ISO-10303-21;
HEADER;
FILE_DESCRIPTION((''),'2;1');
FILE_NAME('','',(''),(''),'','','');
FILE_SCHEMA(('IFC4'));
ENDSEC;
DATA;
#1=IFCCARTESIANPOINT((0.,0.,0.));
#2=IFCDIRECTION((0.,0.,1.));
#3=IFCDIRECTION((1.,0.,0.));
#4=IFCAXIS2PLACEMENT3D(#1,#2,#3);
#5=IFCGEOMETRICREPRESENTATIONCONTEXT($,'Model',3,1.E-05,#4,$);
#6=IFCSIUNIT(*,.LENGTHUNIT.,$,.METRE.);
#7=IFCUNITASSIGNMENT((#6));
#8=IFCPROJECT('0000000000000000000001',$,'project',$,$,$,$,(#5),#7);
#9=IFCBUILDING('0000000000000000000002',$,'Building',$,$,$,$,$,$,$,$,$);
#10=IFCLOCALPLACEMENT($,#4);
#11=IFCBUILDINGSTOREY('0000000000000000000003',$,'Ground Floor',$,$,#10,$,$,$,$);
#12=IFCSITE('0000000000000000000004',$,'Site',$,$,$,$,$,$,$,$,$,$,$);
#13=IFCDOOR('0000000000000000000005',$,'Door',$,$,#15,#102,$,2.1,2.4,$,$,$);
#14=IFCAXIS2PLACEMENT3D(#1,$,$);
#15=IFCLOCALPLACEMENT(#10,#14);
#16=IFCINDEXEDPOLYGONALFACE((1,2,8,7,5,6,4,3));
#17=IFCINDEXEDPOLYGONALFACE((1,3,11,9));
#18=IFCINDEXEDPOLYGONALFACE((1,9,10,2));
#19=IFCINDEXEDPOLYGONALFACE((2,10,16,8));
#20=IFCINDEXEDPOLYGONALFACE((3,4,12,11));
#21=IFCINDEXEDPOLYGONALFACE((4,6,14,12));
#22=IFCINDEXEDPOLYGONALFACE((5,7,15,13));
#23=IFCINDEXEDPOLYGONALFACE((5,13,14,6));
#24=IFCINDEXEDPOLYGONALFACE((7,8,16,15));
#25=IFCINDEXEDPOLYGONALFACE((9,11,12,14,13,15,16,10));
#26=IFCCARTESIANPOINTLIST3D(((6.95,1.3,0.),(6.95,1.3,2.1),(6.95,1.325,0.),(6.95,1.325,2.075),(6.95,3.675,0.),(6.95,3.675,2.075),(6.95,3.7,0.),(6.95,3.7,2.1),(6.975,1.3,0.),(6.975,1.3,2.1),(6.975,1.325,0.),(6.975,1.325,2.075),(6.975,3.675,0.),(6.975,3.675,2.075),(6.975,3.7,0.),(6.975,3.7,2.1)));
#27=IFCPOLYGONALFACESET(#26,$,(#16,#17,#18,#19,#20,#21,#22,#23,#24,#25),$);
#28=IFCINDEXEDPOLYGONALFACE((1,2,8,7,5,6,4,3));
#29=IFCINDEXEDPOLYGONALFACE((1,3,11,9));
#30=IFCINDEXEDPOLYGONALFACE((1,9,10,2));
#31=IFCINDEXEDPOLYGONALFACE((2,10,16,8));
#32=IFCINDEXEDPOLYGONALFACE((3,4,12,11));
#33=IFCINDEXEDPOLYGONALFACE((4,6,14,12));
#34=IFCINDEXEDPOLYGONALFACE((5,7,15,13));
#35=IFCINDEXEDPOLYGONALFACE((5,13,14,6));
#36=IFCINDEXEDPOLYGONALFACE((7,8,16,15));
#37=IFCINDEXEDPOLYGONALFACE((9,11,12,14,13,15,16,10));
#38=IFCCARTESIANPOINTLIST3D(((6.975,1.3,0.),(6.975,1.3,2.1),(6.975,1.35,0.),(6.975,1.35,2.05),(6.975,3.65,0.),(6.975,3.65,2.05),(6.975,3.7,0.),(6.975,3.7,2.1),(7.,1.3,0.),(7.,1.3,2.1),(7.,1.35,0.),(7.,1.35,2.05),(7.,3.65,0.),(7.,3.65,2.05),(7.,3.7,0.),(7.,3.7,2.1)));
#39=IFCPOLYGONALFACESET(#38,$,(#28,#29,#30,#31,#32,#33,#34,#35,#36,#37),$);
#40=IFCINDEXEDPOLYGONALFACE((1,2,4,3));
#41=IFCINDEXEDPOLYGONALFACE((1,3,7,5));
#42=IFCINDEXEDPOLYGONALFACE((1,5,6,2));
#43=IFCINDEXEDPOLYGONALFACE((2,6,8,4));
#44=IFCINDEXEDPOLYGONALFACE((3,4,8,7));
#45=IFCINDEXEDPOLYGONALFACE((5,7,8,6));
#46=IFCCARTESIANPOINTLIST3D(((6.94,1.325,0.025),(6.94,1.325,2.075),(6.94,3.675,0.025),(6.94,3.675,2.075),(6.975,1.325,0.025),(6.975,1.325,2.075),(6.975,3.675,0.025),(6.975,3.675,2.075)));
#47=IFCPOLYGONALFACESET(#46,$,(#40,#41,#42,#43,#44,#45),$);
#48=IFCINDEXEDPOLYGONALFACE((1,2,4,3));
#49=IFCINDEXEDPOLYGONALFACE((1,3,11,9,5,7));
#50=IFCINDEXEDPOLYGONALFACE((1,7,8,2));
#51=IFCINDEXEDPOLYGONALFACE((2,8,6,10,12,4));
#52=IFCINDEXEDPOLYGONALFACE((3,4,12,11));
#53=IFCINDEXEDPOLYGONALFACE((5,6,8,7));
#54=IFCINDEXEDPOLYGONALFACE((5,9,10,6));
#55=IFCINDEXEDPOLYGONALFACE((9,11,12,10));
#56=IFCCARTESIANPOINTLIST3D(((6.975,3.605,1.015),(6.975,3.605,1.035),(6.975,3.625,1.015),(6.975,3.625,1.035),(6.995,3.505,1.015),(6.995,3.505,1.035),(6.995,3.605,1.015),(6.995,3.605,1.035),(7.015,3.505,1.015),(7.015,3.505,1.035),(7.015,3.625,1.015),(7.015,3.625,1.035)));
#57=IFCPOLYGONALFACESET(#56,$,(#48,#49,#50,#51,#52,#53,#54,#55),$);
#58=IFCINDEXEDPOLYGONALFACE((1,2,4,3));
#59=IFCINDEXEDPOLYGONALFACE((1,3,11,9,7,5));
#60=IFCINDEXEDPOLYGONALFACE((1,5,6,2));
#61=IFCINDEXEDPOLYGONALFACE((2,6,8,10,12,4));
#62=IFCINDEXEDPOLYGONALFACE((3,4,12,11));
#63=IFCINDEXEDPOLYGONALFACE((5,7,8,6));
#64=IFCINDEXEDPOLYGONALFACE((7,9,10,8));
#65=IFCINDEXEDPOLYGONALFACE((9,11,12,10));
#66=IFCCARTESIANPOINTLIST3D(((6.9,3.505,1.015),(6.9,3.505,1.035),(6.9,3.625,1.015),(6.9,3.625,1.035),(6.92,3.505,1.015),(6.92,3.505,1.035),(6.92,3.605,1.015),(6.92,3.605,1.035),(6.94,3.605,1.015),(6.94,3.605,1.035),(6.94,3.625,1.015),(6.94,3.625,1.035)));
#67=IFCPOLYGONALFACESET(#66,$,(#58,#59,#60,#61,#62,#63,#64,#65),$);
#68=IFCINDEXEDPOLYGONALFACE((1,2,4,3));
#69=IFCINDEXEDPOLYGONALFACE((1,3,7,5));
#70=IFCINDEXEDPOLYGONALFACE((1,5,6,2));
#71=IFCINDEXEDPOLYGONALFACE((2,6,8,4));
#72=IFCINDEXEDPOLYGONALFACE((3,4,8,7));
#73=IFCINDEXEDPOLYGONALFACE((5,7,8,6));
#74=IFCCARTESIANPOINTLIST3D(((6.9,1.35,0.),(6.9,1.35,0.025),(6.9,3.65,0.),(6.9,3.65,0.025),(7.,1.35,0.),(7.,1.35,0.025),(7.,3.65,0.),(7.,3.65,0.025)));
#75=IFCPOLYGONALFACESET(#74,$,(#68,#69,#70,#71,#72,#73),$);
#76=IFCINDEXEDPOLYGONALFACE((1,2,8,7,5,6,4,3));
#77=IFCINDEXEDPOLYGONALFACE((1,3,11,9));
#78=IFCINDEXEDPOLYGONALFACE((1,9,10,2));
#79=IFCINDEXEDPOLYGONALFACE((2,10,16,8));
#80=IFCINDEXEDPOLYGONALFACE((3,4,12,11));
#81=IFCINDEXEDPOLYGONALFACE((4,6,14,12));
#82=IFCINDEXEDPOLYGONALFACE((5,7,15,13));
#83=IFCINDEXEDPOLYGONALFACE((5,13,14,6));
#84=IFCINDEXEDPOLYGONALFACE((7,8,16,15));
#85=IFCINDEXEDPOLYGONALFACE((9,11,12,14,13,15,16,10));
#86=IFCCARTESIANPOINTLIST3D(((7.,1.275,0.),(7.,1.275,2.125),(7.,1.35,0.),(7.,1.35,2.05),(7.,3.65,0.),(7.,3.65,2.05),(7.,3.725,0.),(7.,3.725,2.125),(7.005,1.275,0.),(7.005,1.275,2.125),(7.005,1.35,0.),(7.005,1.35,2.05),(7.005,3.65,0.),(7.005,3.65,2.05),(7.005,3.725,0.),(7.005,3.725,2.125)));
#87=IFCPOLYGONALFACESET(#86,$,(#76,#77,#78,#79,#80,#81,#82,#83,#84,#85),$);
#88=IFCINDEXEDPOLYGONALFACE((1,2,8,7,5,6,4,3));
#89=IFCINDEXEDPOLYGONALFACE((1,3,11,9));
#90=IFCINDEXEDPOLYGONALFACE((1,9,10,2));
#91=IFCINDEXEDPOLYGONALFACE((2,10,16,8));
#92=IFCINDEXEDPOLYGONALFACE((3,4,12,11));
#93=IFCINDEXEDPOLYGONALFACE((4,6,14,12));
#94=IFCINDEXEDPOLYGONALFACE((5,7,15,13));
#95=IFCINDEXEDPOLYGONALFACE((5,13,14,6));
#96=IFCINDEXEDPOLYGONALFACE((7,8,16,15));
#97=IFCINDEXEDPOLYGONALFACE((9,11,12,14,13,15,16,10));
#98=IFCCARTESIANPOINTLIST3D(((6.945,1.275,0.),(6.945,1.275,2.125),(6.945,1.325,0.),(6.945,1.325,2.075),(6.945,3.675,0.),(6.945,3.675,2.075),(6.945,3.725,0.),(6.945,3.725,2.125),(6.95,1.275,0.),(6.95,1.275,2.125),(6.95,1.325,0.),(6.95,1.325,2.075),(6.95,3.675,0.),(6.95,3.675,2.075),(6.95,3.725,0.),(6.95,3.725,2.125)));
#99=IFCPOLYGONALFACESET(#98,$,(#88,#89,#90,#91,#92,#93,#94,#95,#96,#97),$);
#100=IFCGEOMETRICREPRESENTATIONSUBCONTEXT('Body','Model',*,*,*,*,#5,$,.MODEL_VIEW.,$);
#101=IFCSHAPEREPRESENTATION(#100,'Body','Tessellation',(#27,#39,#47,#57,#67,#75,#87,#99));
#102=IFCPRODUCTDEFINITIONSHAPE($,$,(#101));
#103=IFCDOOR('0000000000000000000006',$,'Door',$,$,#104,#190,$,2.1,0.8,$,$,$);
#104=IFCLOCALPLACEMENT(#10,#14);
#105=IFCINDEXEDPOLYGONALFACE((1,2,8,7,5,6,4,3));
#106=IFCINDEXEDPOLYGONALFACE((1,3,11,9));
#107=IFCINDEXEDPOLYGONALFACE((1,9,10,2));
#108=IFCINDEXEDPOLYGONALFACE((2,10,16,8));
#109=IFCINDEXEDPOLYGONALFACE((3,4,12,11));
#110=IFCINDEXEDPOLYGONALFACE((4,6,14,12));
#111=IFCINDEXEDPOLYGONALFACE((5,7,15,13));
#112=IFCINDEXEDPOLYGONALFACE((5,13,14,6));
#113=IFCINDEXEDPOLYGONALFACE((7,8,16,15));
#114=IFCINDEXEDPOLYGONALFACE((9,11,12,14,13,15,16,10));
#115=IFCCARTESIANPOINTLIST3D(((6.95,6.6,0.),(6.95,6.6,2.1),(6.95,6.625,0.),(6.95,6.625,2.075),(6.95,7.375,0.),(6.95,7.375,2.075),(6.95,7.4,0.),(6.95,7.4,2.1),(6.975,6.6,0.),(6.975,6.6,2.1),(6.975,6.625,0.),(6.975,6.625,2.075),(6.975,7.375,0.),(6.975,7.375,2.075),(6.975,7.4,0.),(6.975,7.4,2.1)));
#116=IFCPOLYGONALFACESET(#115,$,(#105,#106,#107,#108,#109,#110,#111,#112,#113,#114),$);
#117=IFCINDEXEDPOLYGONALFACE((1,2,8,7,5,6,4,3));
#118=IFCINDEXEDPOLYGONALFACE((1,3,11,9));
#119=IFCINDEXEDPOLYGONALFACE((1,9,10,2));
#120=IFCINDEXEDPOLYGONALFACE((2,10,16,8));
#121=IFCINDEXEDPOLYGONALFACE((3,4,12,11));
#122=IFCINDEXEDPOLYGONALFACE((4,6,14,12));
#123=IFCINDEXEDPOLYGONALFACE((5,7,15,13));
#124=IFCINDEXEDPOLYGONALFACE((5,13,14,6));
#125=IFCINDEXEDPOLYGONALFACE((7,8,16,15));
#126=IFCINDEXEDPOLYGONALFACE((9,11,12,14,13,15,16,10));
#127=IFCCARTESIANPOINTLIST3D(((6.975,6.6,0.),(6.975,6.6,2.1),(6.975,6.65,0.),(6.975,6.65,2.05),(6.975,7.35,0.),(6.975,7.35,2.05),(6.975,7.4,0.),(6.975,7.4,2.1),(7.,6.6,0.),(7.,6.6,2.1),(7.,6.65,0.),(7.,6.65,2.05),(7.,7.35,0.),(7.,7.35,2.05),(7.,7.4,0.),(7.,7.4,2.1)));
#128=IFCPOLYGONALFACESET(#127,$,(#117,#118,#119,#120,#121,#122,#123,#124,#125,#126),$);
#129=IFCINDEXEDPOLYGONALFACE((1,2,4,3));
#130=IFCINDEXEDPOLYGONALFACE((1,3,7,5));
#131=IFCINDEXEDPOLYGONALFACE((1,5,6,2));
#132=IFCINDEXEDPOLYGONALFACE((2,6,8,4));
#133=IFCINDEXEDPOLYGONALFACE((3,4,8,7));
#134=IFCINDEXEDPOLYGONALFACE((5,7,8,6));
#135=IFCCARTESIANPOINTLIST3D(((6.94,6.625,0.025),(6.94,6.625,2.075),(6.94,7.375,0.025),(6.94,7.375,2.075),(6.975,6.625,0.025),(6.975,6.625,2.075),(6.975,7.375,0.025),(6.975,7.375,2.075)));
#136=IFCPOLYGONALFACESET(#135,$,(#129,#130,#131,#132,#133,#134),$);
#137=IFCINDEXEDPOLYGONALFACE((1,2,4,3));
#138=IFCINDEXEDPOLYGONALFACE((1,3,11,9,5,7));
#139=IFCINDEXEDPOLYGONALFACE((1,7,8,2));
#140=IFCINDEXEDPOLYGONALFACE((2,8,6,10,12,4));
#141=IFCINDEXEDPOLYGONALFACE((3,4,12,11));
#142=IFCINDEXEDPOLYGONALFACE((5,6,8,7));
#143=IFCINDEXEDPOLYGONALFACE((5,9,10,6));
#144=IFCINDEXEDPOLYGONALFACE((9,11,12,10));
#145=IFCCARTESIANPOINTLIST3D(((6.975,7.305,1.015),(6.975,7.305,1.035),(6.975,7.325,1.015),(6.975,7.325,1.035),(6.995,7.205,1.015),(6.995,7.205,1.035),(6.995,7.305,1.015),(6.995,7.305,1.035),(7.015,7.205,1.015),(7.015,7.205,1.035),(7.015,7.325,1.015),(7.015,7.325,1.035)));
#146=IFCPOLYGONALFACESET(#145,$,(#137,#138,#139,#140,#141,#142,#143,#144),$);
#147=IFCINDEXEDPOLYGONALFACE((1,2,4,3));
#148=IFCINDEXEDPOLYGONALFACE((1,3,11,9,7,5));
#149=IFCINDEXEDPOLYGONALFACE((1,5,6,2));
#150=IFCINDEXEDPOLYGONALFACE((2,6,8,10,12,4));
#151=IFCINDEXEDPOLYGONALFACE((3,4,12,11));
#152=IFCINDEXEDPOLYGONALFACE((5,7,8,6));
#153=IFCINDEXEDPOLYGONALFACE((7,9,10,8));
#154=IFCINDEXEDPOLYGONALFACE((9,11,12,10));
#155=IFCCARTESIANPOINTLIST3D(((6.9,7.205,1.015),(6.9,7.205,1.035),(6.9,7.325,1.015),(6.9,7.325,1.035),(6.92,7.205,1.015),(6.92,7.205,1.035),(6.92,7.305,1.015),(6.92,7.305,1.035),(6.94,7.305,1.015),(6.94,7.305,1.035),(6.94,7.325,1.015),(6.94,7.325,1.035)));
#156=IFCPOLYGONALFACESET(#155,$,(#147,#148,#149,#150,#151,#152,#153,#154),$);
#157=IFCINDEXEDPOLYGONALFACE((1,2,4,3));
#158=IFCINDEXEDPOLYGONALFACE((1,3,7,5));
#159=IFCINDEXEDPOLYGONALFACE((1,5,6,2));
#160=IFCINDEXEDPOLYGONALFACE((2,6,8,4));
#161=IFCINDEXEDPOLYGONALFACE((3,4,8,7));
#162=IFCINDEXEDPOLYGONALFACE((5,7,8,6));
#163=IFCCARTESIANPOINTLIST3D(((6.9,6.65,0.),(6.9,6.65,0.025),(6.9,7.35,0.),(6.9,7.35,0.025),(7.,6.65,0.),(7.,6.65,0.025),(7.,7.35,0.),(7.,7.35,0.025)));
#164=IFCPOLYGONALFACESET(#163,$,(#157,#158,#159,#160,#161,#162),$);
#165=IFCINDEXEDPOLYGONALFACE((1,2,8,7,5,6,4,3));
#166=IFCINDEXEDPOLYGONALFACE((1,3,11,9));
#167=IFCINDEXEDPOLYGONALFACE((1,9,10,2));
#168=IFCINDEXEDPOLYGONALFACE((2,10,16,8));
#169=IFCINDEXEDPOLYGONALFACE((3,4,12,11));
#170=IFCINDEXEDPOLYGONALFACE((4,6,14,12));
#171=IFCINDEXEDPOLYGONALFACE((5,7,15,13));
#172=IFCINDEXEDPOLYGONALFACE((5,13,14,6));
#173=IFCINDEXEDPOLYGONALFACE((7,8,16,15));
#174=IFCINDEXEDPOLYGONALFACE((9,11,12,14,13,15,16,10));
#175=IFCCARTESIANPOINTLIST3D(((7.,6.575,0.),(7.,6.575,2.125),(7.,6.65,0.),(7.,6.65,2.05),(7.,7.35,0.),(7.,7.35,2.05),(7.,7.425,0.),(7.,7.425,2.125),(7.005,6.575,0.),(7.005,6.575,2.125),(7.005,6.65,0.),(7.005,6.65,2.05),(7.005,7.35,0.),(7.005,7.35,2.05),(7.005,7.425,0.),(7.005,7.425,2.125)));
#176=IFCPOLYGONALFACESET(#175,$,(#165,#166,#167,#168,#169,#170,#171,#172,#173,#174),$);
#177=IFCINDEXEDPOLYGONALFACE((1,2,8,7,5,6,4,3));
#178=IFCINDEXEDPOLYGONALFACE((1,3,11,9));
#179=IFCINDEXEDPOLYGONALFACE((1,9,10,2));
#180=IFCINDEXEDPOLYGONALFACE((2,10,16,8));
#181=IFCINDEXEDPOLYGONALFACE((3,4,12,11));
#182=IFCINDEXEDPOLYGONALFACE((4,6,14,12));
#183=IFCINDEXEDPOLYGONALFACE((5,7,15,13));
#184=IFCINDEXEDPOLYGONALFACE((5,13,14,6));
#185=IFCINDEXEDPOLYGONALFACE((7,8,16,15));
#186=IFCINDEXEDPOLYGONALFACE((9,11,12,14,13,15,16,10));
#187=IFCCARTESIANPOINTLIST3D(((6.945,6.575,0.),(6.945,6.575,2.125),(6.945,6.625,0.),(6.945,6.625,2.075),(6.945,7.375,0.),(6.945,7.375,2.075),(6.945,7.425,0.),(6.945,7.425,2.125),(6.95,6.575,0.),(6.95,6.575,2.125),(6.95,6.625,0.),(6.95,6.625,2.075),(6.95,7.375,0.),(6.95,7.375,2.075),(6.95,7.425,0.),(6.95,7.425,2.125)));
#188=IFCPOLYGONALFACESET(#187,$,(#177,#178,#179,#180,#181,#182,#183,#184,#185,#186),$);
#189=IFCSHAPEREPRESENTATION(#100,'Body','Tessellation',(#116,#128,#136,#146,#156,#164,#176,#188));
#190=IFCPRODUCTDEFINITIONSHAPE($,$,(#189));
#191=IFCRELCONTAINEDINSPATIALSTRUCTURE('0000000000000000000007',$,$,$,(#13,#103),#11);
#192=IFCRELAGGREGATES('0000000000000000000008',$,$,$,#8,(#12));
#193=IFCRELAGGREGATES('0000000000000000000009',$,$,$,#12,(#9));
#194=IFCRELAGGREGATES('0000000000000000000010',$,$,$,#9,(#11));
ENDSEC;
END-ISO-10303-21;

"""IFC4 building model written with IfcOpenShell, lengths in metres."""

from ifc_helpers import new_model, si_unit, frame, origin_with_axes, place, context, subcontext, project, spatial, line, indexed_curve, outline, extrude, element, save


model = new_model("IFC4")

# Units and contexts
model_context = context("Model", 3, precision=1e-05, world=origin_with_axes())
body_context = subcontext(model_context, "Body", "Model", "MODEL_VIEW")
ifc_project = project(units=[si_unit("LENGTHUNIT", "METRE")], contexts=[model_context])

# Site, building, storey
site = spatial("IfcSite", under=ifc_project, Name="Site")
building = spatial("IfcBuilding", under=site, Name="Building")
storey_placement = place(None, origin_with_axes())
storey = spatial("IfcBuildingStorey", under=building, at=storey_placement, Name="Ground Floor")

# Doors
door_1_placement = place(storey_placement, frame((7.0, 1.3, 0.0), z_axis=(0.0, 0.0, 1.0), x_axis=(0.0, 1.0, 0.0)))
element("IfcDoor", 1, at=door_1_placement, inside=storey, Name="Door", OverallHeight=2.1, OverallWidth=2.4, context=body_context, shape_type="SweptSolid", body=[
    extrude(outline(indexed_curve([(0.0, 0.0), (0.0, 2.1), (2.4, 2.1), (2.4, 0.0), (2.375, 0.0), (2.375, 2.075), (0.025, 2.075), (0.025, 0.0)], segments=[line(1, 2, 3, 4, 5, 6, 7, 8, 1)])), frame((0.0, 0.025, 0.0), z_axis=(0.0, -1.0, 0.0), x_axis=(1.0, 0.0, 0.0)), (0.0, 0.0, -1.0), 0.025),
    extrude(outline(indexed_curve([(0.0, 0.0), (0.0, 2.1), (2.4, 2.1), (2.4, 0.0), (2.35, 0.0), (2.35, 2.05), (0.05, 2.05), (0.05, 0.0)], segments=[line(1, 2, 3, 4, 5, 6, 7, 8, 1)])), frame((0.0, 0.0, 0.0), z_axis=(0.0, -1.0, 0.0), x_axis=(1.0, 0.0, 0.0)), (0.0, 0.0, -1.0), 0.025),
    extrude(outline(indexed_curve([(0.0, 0.0), (2.35, 0.0), (2.35, 0.035), (0.0, 0.035)], segments=[line(1, 2, 3, 4, 1)])), frame((0.025, 0.025, 0.025), z_axis=(0.0, 0.0, 1.0), x_axis=(1.0, 0.0, 0.0)), (0.0, 0.0, 1.0), 2.05),
    extrude(outline(indexed_curve([(0.0, 0.0), (0.0, -0.04), (-0.12, -0.04), (-0.12, -0.02), (-0.02, -0.02), (-0.02, 0.0)], segments=[line(1, 2, 3, 4, 5, 6, 1)])), frame((2.325, 0.025, 1.015), z_axis=(0.0, 0.0, 1.0), x_axis=(1.0, 0.0, 0.0)), (0.0, 0.0, 1.0), 0.02),
    extrude(outline(indexed_curve([(0.0, 0.0), (0.0, 0.04), (-0.12, 0.04), (-0.12, 0.02), (-0.02, 0.02), (-0.02, 0.0)], segments=[line(1, 2, 3, 4, 5, 6, 1)])), frame((2.325, 0.06, 1.015), z_axis=(0.0, 0.0, 1.0), x_axis=(1.0, 0.0, 0.0)), (0.0, 0.0, 1.0), 0.02),
    extrude(outline(indexed_curve([(0.0, 0.0), (2.3, 0.0), (2.3, 0.1), (0.0, 0.1)], segments=[line(1, 2, 3, 4, 1)])), frame((0.05, 0.0, 0.0), z_axis=(0.0, 0.0, 1.0), x_axis=(1.0, 0.0, 0.0)), (0.0, 0.0, 1.0), 0.025),
    extrude(outline(indexed_curve([(0.0, 0.0), (0.0, 2.125), (2.45, 2.125), (2.45, 0.0), (2.375, 0.0), (2.375, 2.05), (0.075, 2.05), (0.075, 0.0)], segments=[line(1, 2, 3, 4, 5, 6, 7, 8, 1)])), frame((-0.025, -0.005, 0.0), z_axis=(0.0, -1.0, 0.0), x_axis=(1.0, 0.0, 0.0)), (0.0, 0.0, -1.0), 0.005),
    extrude(outline(indexed_curve([(0.0, 0.0), (0.0, 2.125), (2.45, 2.125), (2.45, 0.0), (2.4, 0.0), (2.4, 2.075), (0.05, 2.075), (0.05, 0.0)], segments=[line(1, 2, 3, 4, 5, 6, 7, 8, 1)])), frame((-0.025, 0.05, 0.0), z_axis=(0.0, -1.0, 0.0), x_axis=(1.0, 0.0, 0.0)), (0.0, 0.0, -1.0), 0.005),
])
door_2_placement = place(storey_placement, frame((7.0, 6.6, 0.0), z_axis=(0.0, 0.0, 1.0), x_axis=(0.0, 1.0, 0.0)))
element("IfcDoor", 2, at=door_2_placement, inside=storey, Name="Door", OverallHeight=2.1, OverallWidth=0.8, context=body_context, shape_type="SweptSolid", body=[
    extrude(outline(indexed_curve([(0.0, 0.0), (0.0, 2.1), (0.8, 2.1), (0.8, 0.0), (0.775, 0.0), (0.775, 2.075), (0.025, 2.075), (0.025, 0.0)], segments=[line(1, 2, 3, 4, 5, 6, 7, 8, 1)])), frame((0.0, 0.025, 0.0), z_axis=(0.0, -1.0, 0.0), x_axis=(1.0, 0.0, 0.0)), (0.0, 0.0, -1.0), 0.025),
    extrude(outline(indexed_curve([(0.0, 0.0), (0.0, 2.1), (0.8, 2.1), (0.8, 0.0), (0.75, 0.0), (0.75, 2.05), (0.05, 2.05), (0.05, 0.0)], segments=[line(1, 2, 3, 4, 5, 6, 7, 8, 1)])), frame((0.0, 0.0, 0.0), z_axis=(0.0, -1.0, 0.0), x_axis=(1.0, 0.0, 0.0)), (0.0, 0.0, -1.0), 0.025),
    extrude(outline(indexed_curve([(0.0, 0.0), (0.75, 0.0), (0.75, 0.035), (0.0, 0.035)], segments=[line(1, 2, 3, 4, 1)])), frame((0.025, 0.025, 0.025), z_axis=(0.0, 0.0, 1.0), x_axis=(1.0, 0.0, 0.0)), (0.0, 0.0, 1.0), 2.05),
    extrude(outline(indexed_curve([(0.0, 0.0), (0.0, -0.04), (-0.12, -0.04), (-0.12, -0.02), (-0.02, -0.02), (-0.02, 0.0)], segments=[line(1, 2, 3, 4, 5, 6, 1)])), frame((0.725, 0.025, 1.015), z_axis=(0.0, 0.0, 1.0), x_axis=(1.0, 0.0, 0.0)), (0.0, 0.0, 1.0), 0.02),
    extrude(outline(indexed_curve([(0.0, 0.0), (0.0, 0.04), (-0.12, 0.04), (-0.12, 0.02), (-0.02, 0.02), (-0.02, 0.0)], segments=[line(1, 2, 3, 4, 5, 6, 1)])), frame((0.725, 0.06, 1.015), z_axis=(0.0, 0.0, 1.0), x_axis=(1.0, 0.0, 0.0)), (0.0, 0.0, 1.0), 0.02),
    extrude(outline(indexed_curve([(0.0, 0.0), (0.7, 0.0), (0.7, 0.1), (0.0, 0.1)], segments=[line(1, 2, 3, 4, 1)])), frame((0.05, 0.0, 0.0), z_axis=(0.0, 0.0, 1.0), x_axis=(1.0, 0.0, 0.0)), (0.0, 0.0, 1.0), 0.025),
    extrude(outline(indexed_curve([(0.0, 0.0), (0.0, 2.125), (0.85, 2.125), (0.85, 0.0), (0.775, 0.0), (0.775, 2.05), (0.075, 2.05), (0.075, 0.0)], segments=[line(1, 2, 3, 4, 5, 6, 7, 8, 1)])), frame((-0.025, -0.005, 0.0), z_axis=(0.0, -1.0, 0.0), x_axis=(1.0, 0.0, 0.0)), (0.0, 0.0, -1.0), 0.005),
    extrude(outline(indexed_curve([(0.0, 0.0), (0.0, 2.125), (0.85, 2.125), (0.85, 0.0), (0.8, 0.0), (0.8, 2.075), (0.05, 2.075), (0.05, 0.0)], segments=[line(1, 2, 3, 4, 5, 6, 7, 8, 1)])), frame((-0.025, 0.05, 0.0), z_axis=(0.0, -1.0, 0.0), x_axis=(1.0, 0.0, 0.0)), (0.0, 0.0, -1.0), 0.005),
])

save(model, "model.ifc")
